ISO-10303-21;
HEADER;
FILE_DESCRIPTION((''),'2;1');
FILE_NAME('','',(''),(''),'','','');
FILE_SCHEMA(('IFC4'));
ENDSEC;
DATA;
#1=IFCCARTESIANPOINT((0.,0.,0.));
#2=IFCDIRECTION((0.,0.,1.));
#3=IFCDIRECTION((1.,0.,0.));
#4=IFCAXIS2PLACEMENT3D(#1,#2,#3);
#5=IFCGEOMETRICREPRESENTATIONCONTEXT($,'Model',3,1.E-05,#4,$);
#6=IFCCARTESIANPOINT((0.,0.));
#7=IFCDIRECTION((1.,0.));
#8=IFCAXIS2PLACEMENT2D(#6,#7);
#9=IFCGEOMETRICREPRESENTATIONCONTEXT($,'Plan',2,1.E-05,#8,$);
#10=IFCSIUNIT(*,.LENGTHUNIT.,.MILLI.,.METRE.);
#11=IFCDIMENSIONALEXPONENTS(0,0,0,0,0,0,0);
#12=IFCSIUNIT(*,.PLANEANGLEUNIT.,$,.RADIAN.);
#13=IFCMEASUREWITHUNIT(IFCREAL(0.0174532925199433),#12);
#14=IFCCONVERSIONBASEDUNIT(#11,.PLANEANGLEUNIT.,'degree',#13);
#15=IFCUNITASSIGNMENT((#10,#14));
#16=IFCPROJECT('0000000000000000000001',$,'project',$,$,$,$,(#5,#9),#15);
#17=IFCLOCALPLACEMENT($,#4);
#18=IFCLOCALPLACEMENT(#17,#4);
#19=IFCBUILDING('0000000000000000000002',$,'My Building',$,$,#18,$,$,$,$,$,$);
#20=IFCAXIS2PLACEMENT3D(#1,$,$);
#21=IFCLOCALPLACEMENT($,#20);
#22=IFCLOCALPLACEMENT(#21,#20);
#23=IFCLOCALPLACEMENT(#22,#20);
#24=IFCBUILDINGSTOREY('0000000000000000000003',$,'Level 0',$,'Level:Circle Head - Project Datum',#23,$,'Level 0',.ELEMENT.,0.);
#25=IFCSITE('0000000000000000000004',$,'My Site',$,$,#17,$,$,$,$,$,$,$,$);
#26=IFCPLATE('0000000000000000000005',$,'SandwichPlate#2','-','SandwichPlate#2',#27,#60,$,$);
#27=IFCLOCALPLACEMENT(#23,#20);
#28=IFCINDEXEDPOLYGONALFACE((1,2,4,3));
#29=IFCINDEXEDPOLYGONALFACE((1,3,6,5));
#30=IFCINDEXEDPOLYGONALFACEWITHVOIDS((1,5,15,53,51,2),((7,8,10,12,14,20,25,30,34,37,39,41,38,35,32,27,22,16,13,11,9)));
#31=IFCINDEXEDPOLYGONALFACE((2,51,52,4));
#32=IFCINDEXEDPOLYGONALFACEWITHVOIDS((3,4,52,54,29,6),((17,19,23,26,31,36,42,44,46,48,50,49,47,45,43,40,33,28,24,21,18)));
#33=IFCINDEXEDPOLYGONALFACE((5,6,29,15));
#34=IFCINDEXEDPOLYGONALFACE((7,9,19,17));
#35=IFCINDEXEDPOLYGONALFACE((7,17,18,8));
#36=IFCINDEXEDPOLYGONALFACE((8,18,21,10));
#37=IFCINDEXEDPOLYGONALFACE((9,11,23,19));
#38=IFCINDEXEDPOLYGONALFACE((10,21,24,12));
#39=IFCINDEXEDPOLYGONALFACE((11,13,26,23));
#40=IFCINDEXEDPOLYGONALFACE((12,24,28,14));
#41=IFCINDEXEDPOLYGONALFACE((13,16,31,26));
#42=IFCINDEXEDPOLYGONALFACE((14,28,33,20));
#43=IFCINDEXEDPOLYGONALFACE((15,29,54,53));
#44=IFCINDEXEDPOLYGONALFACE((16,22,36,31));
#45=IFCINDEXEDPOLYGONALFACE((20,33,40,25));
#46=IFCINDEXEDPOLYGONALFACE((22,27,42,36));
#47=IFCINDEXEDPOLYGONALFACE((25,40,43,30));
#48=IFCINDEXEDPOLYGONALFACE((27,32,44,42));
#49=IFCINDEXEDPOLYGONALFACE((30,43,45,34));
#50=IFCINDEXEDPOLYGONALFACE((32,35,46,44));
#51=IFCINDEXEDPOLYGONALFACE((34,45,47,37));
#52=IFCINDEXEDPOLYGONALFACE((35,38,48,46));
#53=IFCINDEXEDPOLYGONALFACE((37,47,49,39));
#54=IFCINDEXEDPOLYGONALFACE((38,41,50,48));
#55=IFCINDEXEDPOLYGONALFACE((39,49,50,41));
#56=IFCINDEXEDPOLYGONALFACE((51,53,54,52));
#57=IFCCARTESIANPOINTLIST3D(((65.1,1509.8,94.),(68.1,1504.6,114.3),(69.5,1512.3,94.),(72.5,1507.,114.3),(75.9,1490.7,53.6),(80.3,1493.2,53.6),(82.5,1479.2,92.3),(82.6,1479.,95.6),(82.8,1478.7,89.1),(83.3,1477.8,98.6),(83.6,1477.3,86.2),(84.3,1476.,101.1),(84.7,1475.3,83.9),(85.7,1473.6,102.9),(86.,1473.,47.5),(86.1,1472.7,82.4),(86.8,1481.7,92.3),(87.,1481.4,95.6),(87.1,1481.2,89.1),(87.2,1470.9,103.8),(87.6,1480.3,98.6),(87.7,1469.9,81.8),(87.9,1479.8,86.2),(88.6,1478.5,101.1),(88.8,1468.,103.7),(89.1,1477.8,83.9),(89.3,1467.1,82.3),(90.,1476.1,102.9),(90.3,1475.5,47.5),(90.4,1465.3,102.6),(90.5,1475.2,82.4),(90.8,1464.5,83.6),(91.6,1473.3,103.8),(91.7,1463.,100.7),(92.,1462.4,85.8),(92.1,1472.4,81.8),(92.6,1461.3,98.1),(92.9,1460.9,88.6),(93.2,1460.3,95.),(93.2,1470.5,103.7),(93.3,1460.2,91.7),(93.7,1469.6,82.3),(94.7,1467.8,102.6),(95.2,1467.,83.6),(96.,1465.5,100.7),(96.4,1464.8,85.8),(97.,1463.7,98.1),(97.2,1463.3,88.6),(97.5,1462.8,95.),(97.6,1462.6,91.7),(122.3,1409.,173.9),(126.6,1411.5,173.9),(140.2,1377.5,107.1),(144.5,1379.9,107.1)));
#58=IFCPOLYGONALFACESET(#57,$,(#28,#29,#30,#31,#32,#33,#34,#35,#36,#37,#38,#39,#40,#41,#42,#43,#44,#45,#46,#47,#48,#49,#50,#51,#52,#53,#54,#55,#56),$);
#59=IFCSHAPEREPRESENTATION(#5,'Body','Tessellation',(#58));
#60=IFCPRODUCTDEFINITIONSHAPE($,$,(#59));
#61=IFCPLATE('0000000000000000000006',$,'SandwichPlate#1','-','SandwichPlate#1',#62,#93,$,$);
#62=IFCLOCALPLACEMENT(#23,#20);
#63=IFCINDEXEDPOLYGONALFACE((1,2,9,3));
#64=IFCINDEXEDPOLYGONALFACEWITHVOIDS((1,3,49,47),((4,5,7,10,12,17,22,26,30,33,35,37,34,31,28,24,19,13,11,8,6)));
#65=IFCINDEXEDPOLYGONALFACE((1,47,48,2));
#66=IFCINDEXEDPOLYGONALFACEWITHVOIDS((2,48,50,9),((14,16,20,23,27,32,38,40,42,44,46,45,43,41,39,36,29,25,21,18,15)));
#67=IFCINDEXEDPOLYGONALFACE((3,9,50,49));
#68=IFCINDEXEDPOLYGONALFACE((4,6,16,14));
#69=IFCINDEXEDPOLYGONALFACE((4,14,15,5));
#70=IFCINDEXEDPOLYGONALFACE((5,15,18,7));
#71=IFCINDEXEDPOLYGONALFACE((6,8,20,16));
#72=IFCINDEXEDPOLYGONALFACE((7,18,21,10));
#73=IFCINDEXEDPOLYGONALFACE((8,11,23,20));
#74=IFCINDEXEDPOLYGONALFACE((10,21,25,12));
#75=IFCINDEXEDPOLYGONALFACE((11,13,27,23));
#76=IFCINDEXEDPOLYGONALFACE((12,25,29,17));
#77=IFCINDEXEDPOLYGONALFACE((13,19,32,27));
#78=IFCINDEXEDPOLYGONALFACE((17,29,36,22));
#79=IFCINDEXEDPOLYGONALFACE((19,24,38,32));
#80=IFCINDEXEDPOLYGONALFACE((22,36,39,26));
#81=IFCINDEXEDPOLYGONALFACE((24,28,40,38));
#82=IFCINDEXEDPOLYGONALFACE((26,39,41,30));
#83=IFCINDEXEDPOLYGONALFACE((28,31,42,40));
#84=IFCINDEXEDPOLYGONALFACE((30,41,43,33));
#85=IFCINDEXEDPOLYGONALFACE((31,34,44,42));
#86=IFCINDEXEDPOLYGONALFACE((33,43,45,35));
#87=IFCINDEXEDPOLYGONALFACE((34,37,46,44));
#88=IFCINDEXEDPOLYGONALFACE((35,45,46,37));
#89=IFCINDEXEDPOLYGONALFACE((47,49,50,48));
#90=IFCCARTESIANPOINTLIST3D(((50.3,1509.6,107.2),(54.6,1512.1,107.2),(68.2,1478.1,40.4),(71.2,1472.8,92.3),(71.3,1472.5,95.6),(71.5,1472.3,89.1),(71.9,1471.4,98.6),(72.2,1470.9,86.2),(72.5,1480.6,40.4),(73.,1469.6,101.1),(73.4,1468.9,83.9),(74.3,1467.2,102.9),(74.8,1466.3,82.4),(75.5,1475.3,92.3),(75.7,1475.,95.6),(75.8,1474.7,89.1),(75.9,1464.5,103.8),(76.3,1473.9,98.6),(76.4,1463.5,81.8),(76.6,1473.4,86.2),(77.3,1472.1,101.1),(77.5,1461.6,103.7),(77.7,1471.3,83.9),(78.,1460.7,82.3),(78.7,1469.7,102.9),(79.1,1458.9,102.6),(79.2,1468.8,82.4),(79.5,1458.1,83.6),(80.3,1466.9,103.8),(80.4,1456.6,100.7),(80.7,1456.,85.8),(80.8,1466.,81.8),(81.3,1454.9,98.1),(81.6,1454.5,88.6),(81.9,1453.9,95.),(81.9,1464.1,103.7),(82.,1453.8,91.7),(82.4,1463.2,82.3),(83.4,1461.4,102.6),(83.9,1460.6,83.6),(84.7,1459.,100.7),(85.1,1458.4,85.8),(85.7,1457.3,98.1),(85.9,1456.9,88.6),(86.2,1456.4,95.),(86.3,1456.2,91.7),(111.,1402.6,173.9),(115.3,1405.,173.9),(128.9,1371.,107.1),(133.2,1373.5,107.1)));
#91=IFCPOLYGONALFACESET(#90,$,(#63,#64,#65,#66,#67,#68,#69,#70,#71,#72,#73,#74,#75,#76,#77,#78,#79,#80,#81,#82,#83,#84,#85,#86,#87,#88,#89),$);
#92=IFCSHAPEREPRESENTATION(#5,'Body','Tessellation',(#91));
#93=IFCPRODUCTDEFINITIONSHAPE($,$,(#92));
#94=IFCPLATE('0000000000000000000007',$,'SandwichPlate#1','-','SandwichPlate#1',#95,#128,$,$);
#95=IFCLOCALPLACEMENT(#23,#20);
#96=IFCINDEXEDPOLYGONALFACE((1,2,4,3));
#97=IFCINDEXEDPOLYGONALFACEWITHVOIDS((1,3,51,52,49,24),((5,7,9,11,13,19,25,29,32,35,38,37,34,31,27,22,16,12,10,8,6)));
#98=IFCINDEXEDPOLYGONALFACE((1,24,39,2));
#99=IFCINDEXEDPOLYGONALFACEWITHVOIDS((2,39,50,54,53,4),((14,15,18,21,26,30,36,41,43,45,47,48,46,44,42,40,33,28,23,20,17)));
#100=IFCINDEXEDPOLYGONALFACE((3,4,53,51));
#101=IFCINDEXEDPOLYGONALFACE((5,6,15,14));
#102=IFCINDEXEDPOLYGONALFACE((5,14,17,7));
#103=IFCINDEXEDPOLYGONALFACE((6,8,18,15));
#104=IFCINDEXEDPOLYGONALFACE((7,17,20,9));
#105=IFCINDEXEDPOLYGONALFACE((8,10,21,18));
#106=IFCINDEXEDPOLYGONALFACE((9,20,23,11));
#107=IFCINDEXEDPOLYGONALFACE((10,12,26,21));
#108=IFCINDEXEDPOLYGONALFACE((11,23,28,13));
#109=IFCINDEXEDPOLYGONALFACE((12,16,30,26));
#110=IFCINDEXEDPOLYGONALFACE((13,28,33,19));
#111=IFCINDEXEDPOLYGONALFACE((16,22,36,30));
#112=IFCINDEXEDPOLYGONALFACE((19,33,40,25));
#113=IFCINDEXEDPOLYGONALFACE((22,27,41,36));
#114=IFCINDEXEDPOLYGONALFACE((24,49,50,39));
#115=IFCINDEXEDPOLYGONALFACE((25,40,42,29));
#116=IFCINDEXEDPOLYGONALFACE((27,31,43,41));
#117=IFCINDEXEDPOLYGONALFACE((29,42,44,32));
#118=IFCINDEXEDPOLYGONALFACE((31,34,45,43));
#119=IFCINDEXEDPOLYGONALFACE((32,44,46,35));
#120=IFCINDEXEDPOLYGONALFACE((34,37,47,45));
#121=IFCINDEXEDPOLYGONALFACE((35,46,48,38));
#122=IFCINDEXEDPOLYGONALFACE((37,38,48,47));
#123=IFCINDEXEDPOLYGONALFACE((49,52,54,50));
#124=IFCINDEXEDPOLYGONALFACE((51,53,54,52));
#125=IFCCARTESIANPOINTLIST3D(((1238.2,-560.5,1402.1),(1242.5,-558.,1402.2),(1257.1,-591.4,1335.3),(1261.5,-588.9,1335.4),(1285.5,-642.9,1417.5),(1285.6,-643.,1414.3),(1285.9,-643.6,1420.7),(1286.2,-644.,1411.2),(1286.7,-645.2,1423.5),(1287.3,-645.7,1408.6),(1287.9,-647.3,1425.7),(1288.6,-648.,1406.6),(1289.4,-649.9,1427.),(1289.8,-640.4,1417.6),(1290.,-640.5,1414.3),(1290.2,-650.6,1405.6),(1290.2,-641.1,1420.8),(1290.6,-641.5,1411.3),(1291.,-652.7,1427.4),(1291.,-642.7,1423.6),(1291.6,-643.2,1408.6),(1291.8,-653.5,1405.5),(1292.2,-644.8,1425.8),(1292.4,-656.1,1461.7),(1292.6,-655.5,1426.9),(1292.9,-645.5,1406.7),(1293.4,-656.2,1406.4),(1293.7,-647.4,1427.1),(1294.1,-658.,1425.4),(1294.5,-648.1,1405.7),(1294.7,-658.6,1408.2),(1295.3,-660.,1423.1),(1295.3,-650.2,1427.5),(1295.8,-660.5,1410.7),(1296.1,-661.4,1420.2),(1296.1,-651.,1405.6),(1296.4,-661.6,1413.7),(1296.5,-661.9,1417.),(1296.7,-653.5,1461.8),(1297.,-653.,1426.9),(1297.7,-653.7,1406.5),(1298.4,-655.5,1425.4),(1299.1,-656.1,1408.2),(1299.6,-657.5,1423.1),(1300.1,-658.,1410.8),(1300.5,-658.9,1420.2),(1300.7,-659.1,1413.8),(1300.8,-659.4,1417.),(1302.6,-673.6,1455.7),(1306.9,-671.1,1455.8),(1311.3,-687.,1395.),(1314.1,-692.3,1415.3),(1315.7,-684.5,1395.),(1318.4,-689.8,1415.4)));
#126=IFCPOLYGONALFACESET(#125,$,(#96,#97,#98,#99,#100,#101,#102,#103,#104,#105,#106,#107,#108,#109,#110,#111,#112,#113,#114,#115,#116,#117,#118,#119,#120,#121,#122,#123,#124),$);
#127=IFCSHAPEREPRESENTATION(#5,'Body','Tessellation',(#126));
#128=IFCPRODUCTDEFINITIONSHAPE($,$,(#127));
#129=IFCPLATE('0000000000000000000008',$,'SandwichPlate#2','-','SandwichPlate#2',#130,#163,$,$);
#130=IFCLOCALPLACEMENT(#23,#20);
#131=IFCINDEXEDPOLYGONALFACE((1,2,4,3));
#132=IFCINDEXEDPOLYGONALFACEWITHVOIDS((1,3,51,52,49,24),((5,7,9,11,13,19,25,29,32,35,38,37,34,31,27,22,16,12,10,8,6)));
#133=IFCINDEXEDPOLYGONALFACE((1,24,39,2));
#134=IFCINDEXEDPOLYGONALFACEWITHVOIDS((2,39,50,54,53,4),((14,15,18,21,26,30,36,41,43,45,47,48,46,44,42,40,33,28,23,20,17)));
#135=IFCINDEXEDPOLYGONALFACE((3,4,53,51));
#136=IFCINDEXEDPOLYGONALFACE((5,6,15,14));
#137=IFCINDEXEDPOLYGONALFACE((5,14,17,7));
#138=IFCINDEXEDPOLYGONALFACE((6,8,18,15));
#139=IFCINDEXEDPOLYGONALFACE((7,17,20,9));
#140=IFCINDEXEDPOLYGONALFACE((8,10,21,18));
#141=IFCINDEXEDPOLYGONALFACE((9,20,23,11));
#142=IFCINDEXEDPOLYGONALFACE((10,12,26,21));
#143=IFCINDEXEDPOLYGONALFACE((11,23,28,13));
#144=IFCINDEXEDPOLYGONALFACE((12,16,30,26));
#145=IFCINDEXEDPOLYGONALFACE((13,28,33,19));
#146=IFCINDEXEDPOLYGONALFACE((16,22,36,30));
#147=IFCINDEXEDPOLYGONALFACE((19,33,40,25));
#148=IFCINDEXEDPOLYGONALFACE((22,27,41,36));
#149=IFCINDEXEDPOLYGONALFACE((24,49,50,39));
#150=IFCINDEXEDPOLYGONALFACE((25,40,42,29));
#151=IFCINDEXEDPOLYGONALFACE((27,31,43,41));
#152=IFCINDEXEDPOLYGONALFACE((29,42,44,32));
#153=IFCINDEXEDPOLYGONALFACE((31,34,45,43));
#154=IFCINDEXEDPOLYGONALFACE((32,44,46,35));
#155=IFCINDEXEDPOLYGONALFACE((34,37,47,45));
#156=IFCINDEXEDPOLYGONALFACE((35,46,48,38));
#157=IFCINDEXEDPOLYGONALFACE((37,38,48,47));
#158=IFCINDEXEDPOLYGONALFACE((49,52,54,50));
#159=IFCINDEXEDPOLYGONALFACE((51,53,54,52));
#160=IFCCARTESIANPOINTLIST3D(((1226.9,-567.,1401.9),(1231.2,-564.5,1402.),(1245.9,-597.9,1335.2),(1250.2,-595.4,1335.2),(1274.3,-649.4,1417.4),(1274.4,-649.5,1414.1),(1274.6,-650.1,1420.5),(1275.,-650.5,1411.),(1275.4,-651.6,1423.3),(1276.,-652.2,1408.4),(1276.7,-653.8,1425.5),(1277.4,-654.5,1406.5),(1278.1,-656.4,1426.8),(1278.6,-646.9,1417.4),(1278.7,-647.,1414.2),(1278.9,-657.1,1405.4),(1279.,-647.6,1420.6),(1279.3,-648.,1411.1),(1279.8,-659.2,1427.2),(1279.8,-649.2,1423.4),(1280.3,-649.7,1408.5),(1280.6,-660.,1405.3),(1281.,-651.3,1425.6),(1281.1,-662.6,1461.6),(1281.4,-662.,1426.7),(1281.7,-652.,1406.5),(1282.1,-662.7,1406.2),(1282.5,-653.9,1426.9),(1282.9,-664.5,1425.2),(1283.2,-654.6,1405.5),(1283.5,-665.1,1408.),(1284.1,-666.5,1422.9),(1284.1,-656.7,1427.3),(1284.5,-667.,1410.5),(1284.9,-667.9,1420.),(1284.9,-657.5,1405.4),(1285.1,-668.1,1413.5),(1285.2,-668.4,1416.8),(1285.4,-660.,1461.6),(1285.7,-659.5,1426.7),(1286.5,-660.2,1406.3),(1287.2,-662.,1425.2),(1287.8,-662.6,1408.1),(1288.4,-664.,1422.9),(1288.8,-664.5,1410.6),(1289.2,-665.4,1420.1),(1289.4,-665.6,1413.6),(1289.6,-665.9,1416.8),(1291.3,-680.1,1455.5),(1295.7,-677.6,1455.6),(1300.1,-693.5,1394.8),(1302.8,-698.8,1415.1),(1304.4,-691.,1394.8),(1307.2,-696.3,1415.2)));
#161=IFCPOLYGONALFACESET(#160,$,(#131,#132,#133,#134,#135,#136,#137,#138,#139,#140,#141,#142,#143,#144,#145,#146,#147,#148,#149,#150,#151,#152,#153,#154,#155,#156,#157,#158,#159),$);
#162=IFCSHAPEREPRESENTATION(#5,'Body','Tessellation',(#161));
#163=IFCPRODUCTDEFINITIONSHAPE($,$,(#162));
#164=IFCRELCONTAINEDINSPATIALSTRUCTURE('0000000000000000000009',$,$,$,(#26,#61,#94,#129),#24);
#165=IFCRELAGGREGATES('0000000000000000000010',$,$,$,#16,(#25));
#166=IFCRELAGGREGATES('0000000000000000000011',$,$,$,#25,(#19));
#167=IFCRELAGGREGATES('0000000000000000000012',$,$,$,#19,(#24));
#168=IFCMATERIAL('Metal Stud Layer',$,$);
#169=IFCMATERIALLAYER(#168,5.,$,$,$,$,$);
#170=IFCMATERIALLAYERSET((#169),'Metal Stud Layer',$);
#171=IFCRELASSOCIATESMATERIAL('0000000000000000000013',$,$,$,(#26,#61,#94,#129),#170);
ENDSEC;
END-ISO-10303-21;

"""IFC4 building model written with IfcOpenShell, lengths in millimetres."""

from ifc_helpers import new_model, entity, si_unit, converted_unit, frame, origin, origin_with_axes, origin_2d_with_axis, place, context, project, spatial, polyline, circle, outline, extrude, material, layer, layer_set, element, save


model = new_model("IFC4")

# Units and contexts
model_context = context("Model", 3, precision=1e-05, world=origin_with_axes())
plan_context = context("Plan", 2, precision=1e-05, world=origin_2d_with_axis())
ifc_project = project(units=[si_unit("LENGTHUNIT", "METRE", prefix="MILLI"), converted_unit("PLANEANGLEUNIT", "degree", entity("IfcReal", 0.0174532925199433), si_unit("PLANEANGLEUNIT", "RADIAN"), dimensions=[0, 0, 0, 0, 0, 0, 0])], contexts=[model_context, plan_context])

# Site, building, storey
site_placement = place(None, origin_with_axes())
site = spatial("IfcSite", under=ifc_project, at=site_placement, Name="My Site")
building_placement = place(site_placement, origin_with_axes())
building = spatial("IfcBuilding", under=site, at=building_placement, Name="My Building")
placement_1 = place(None, origin())
placement_2 = place(placement_1, origin())
storey_placement = place(placement_2, origin())
storey = spatial("IfcBuildingStorey", under=building, at=storey_placement, Name="Level 0", ObjectType="Level:Circle Head - Project Datum", LongName="Level 0", CompositionType="ELEMENT", Elevation=0.0)

# Plates, openings
ifc_material_1 = material(Name="Metal Stud Layer")
ifc_layer_1 = layer(ifc_material_1, 5.0)
ifc_layer_set_1 = layer_set([ifc_layer_1], Name="Metal Stud Layer")
plate_1_placement = place(storey_placement, frame((66.0, 1518.5, 107.2), z_axis=(-0.869914, -0.493203, 0.0), x_axis=(0.235201, -0.41485, -0.878965)))
plate_1 = element("IfcPlate", 1, at=plate_1_placement, inside=storey, material=ifc_layer_set_1, Name="SandwichPlate#2", Description="-", ObjectType="SandwichPlate#2", context=model_context, shape_type="SweptSolid", body=[
    extrude(outline(polyline([(15.0, 0.0), (61.0, 0.0), (76.0, 15.0), (76.0, 140.0), (0.0, 140.0), (0.0, 15.0), (15.0, 0.0)])), origin_with_axes(), (0.0, 0.0, 1.0), 5.0),
])
opening_1_placement = place(plate_1_placement, frame((38.0, 40.0, -0.5), z_axis=(0.0, 0.0, 1.0), x_axis=(0.0, 1.0, 0.0)))
element("IfcOpeningElement", 2, at=opening_1_placement, cuts=plate_1, ObjectType="Opening", context=model_context, shape_type="SweptSolid", body=[
    extrude(circle(Radius=11.0, at=origin_2d_with_axis()), origin(), (0.0, 0.0, 1.0), 6.0),
])
plate_2_placement = place(storey_placement, frame((54.6, 1512.1, 107.2), z_axis=(-0.869914, -0.493203, 0.0), x_axis=(0.235201, -0.41485, -0.878965)))
plate_2 = element("IfcPlate", 3, at=plate_2_placement, inside=storey, material=ifc_layer_set_1, Name="SandwichPlate#1", Description="-", ObjectType="SandwichPlate#1", context=model_context, shape_type="SweptSolid", body=[
    extrude(outline(polyline([(0.0, 0.0), (76.0, 0.0), (76.0, 140.0), (0.0, 140.0), (0.0, 0.0)])), origin_with_axes(), (0.0, 0.0, 1.0), 5.0),
])
opening_2_placement = place(plate_2_placement, frame((38.0, 40.0, -0.5), z_axis=(0.0, 0.0, 1.0), x_axis=(0.0, 1.0, 0.0)))
element("IfcOpeningElement", 4, at=opening_2_placement, cuts=plate_2, ObjectType="Opening", context=model_context, shape_type="SweptSolid", body=[
    extrude(circle(Radius=11.0, at=origin_2d_with_axis()), origin(), (0.0, 0.0, 1.0), 6.0),
])

# Plates, openings
plate_3_placement = place(storey_placement, frame((1322.2, -695.9, 1402.2), z_axis=(-0.865935, -0.499948, -0.014432), x_axis=(-0.249453, 0.406695, 0.878847)))
plate_3 = element("IfcPlate", 5, at=plate_3_placement, inside=storey, material=ifc_layer_set_1, Name="SandwichPlate#1", Description="-", ObjectType="SandwichPlate#1", context=model_context, shape_type="SweptSolid", body=[
    extrude(outline(polyline([(0.0, 0.0), (76.0, 0.0), (76.0, 140.0), (0.0, 140.0), (0.0, 0.0)])), origin_with_axes(), (0.0, 0.0, 1.0), 5.0),
])
opening_3_placement = place(plate_3_placement, frame((0.0, 0.0, 0.0), z_axis=(0.0, 0.0, 1.0), x_axis=(1.0, 0.0, 0.0)))
element("IfcOpeningElement", 6, at=opening_3_placement, cuts=plate_3, ObjectType="Opening", context=model_context, shape_type="SweptSolid", body=[
    extrude(outline(polyline([(0.0, 0.0), (15.0, 0.0), (0.0, 15.0), (0.0, 0.0)])), origin(), (0.0, 0.0, 1.0), 5.0),
])
opening_4_placement = place(plate_3_placement, frame((0.0, 0.0, 0.0), z_axis=(0.0, 0.0, 1.0), x_axis=(1.0, 0.0, 0.0)))
element("IfcOpeningElement", 7, at=opening_4_placement, cuts=plate_3, ObjectType="Opening", context=model_context, shape_type="SweptSolid", body=[
    extrude(outline(polyline([(76.0, 0.0), (76.0, 15.0), (61.0, 0.0), (76.0, 0.0)])), origin(), (0.0, 0.0, 1.0), 5.0),
])
opening_5_placement = place(plate_3_placement, frame((38.0, 40.0, -0.5), z_axis=(0.0, 0.0, 1.0), x_axis=(0.0, 1.0, 0.0)))
element("IfcOpeningElement", 8, at=opening_5_placement, cuts=plate_3, ObjectType="Opening", context=model_context, shape_type="SweptSolid", body=[
    extrude(circle(Radius=11.0, at=origin_2d_with_axis()), origin(), (0.0, 0.0, 1.0), 6.0),
])
plate_4_placement = place(storey_placement, frame((1310.9, -702.4, 1402.0), z_axis=(-0.865935, -0.499948, -0.014432), x_axis=(-0.249453, 0.406695, 0.878847)))
plate_4 = element("IfcPlate", 9, at=plate_4_placement, inside=storey, material=ifc_layer_set_1, Name="SandwichPlate#2", Description="-", ObjectType="SandwichPlate#2", context=model_context, shape_type="SweptSolid", body=[
    extrude(outline(polyline([(0.0, 0.0), (76.0, 0.0), (76.0, 140.0), (0.0, 140.0), (0.0, 0.0)])), origin_with_axes(), (0.0, 0.0, 1.0), 5.0),
])
opening_6_placement = place(plate_4_placement, frame((0.0, 0.0, 0.0), z_axis=(0.0, 0.0, 1.0), x_axis=(1.0, 0.0, 0.0)))
element("IfcOpeningElement", 10, at=opening_6_placement, cuts=plate_4, ObjectType="Opening", context=model_context, shape_type="SweptSolid", body=[
    extrude(outline(polyline([(0.0, 0.0), (15.0, 0.0), (0.0, 15.0), (0.0, 0.0)])), origin(), (0.0, 0.0, 1.0), 5.0),
])
opening_7_placement = place(plate_4_placement, frame((0.0, 0.0, 0.0), z_axis=(0.0, 0.0, 1.0), x_axis=(1.0, 0.0, 0.0)))
element("IfcOpeningElement", 11, at=opening_7_placement, cuts=plate_4, ObjectType="Opening", context=model_context, shape_type="SweptSolid", body=[
    extrude(outline(polyline([(76.0, 0.0), (76.0, 15.0), (61.0, 0.0), (76.0, 0.0)])), origin(), (0.0, 0.0, 1.0), 5.0),
])
opening_8_placement = place(plate_4_placement, frame((38.0, 40.0, -0.5), z_axis=(0.0, 0.0, 1.0), x_axis=(0.0, 1.0, 0.0)))
element("IfcOpeningElement", 12, at=opening_8_placement, cuts=plate_4, ObjectType="Opening", context=model_context, shape_type="SweptSolid", body=[
    extrude(circle(Radius=11.0, at=origin_2d_with_axis()), origin(), (0.0, 0.0, 1.0), 6.0),
])

save(model, "model.ifc")
